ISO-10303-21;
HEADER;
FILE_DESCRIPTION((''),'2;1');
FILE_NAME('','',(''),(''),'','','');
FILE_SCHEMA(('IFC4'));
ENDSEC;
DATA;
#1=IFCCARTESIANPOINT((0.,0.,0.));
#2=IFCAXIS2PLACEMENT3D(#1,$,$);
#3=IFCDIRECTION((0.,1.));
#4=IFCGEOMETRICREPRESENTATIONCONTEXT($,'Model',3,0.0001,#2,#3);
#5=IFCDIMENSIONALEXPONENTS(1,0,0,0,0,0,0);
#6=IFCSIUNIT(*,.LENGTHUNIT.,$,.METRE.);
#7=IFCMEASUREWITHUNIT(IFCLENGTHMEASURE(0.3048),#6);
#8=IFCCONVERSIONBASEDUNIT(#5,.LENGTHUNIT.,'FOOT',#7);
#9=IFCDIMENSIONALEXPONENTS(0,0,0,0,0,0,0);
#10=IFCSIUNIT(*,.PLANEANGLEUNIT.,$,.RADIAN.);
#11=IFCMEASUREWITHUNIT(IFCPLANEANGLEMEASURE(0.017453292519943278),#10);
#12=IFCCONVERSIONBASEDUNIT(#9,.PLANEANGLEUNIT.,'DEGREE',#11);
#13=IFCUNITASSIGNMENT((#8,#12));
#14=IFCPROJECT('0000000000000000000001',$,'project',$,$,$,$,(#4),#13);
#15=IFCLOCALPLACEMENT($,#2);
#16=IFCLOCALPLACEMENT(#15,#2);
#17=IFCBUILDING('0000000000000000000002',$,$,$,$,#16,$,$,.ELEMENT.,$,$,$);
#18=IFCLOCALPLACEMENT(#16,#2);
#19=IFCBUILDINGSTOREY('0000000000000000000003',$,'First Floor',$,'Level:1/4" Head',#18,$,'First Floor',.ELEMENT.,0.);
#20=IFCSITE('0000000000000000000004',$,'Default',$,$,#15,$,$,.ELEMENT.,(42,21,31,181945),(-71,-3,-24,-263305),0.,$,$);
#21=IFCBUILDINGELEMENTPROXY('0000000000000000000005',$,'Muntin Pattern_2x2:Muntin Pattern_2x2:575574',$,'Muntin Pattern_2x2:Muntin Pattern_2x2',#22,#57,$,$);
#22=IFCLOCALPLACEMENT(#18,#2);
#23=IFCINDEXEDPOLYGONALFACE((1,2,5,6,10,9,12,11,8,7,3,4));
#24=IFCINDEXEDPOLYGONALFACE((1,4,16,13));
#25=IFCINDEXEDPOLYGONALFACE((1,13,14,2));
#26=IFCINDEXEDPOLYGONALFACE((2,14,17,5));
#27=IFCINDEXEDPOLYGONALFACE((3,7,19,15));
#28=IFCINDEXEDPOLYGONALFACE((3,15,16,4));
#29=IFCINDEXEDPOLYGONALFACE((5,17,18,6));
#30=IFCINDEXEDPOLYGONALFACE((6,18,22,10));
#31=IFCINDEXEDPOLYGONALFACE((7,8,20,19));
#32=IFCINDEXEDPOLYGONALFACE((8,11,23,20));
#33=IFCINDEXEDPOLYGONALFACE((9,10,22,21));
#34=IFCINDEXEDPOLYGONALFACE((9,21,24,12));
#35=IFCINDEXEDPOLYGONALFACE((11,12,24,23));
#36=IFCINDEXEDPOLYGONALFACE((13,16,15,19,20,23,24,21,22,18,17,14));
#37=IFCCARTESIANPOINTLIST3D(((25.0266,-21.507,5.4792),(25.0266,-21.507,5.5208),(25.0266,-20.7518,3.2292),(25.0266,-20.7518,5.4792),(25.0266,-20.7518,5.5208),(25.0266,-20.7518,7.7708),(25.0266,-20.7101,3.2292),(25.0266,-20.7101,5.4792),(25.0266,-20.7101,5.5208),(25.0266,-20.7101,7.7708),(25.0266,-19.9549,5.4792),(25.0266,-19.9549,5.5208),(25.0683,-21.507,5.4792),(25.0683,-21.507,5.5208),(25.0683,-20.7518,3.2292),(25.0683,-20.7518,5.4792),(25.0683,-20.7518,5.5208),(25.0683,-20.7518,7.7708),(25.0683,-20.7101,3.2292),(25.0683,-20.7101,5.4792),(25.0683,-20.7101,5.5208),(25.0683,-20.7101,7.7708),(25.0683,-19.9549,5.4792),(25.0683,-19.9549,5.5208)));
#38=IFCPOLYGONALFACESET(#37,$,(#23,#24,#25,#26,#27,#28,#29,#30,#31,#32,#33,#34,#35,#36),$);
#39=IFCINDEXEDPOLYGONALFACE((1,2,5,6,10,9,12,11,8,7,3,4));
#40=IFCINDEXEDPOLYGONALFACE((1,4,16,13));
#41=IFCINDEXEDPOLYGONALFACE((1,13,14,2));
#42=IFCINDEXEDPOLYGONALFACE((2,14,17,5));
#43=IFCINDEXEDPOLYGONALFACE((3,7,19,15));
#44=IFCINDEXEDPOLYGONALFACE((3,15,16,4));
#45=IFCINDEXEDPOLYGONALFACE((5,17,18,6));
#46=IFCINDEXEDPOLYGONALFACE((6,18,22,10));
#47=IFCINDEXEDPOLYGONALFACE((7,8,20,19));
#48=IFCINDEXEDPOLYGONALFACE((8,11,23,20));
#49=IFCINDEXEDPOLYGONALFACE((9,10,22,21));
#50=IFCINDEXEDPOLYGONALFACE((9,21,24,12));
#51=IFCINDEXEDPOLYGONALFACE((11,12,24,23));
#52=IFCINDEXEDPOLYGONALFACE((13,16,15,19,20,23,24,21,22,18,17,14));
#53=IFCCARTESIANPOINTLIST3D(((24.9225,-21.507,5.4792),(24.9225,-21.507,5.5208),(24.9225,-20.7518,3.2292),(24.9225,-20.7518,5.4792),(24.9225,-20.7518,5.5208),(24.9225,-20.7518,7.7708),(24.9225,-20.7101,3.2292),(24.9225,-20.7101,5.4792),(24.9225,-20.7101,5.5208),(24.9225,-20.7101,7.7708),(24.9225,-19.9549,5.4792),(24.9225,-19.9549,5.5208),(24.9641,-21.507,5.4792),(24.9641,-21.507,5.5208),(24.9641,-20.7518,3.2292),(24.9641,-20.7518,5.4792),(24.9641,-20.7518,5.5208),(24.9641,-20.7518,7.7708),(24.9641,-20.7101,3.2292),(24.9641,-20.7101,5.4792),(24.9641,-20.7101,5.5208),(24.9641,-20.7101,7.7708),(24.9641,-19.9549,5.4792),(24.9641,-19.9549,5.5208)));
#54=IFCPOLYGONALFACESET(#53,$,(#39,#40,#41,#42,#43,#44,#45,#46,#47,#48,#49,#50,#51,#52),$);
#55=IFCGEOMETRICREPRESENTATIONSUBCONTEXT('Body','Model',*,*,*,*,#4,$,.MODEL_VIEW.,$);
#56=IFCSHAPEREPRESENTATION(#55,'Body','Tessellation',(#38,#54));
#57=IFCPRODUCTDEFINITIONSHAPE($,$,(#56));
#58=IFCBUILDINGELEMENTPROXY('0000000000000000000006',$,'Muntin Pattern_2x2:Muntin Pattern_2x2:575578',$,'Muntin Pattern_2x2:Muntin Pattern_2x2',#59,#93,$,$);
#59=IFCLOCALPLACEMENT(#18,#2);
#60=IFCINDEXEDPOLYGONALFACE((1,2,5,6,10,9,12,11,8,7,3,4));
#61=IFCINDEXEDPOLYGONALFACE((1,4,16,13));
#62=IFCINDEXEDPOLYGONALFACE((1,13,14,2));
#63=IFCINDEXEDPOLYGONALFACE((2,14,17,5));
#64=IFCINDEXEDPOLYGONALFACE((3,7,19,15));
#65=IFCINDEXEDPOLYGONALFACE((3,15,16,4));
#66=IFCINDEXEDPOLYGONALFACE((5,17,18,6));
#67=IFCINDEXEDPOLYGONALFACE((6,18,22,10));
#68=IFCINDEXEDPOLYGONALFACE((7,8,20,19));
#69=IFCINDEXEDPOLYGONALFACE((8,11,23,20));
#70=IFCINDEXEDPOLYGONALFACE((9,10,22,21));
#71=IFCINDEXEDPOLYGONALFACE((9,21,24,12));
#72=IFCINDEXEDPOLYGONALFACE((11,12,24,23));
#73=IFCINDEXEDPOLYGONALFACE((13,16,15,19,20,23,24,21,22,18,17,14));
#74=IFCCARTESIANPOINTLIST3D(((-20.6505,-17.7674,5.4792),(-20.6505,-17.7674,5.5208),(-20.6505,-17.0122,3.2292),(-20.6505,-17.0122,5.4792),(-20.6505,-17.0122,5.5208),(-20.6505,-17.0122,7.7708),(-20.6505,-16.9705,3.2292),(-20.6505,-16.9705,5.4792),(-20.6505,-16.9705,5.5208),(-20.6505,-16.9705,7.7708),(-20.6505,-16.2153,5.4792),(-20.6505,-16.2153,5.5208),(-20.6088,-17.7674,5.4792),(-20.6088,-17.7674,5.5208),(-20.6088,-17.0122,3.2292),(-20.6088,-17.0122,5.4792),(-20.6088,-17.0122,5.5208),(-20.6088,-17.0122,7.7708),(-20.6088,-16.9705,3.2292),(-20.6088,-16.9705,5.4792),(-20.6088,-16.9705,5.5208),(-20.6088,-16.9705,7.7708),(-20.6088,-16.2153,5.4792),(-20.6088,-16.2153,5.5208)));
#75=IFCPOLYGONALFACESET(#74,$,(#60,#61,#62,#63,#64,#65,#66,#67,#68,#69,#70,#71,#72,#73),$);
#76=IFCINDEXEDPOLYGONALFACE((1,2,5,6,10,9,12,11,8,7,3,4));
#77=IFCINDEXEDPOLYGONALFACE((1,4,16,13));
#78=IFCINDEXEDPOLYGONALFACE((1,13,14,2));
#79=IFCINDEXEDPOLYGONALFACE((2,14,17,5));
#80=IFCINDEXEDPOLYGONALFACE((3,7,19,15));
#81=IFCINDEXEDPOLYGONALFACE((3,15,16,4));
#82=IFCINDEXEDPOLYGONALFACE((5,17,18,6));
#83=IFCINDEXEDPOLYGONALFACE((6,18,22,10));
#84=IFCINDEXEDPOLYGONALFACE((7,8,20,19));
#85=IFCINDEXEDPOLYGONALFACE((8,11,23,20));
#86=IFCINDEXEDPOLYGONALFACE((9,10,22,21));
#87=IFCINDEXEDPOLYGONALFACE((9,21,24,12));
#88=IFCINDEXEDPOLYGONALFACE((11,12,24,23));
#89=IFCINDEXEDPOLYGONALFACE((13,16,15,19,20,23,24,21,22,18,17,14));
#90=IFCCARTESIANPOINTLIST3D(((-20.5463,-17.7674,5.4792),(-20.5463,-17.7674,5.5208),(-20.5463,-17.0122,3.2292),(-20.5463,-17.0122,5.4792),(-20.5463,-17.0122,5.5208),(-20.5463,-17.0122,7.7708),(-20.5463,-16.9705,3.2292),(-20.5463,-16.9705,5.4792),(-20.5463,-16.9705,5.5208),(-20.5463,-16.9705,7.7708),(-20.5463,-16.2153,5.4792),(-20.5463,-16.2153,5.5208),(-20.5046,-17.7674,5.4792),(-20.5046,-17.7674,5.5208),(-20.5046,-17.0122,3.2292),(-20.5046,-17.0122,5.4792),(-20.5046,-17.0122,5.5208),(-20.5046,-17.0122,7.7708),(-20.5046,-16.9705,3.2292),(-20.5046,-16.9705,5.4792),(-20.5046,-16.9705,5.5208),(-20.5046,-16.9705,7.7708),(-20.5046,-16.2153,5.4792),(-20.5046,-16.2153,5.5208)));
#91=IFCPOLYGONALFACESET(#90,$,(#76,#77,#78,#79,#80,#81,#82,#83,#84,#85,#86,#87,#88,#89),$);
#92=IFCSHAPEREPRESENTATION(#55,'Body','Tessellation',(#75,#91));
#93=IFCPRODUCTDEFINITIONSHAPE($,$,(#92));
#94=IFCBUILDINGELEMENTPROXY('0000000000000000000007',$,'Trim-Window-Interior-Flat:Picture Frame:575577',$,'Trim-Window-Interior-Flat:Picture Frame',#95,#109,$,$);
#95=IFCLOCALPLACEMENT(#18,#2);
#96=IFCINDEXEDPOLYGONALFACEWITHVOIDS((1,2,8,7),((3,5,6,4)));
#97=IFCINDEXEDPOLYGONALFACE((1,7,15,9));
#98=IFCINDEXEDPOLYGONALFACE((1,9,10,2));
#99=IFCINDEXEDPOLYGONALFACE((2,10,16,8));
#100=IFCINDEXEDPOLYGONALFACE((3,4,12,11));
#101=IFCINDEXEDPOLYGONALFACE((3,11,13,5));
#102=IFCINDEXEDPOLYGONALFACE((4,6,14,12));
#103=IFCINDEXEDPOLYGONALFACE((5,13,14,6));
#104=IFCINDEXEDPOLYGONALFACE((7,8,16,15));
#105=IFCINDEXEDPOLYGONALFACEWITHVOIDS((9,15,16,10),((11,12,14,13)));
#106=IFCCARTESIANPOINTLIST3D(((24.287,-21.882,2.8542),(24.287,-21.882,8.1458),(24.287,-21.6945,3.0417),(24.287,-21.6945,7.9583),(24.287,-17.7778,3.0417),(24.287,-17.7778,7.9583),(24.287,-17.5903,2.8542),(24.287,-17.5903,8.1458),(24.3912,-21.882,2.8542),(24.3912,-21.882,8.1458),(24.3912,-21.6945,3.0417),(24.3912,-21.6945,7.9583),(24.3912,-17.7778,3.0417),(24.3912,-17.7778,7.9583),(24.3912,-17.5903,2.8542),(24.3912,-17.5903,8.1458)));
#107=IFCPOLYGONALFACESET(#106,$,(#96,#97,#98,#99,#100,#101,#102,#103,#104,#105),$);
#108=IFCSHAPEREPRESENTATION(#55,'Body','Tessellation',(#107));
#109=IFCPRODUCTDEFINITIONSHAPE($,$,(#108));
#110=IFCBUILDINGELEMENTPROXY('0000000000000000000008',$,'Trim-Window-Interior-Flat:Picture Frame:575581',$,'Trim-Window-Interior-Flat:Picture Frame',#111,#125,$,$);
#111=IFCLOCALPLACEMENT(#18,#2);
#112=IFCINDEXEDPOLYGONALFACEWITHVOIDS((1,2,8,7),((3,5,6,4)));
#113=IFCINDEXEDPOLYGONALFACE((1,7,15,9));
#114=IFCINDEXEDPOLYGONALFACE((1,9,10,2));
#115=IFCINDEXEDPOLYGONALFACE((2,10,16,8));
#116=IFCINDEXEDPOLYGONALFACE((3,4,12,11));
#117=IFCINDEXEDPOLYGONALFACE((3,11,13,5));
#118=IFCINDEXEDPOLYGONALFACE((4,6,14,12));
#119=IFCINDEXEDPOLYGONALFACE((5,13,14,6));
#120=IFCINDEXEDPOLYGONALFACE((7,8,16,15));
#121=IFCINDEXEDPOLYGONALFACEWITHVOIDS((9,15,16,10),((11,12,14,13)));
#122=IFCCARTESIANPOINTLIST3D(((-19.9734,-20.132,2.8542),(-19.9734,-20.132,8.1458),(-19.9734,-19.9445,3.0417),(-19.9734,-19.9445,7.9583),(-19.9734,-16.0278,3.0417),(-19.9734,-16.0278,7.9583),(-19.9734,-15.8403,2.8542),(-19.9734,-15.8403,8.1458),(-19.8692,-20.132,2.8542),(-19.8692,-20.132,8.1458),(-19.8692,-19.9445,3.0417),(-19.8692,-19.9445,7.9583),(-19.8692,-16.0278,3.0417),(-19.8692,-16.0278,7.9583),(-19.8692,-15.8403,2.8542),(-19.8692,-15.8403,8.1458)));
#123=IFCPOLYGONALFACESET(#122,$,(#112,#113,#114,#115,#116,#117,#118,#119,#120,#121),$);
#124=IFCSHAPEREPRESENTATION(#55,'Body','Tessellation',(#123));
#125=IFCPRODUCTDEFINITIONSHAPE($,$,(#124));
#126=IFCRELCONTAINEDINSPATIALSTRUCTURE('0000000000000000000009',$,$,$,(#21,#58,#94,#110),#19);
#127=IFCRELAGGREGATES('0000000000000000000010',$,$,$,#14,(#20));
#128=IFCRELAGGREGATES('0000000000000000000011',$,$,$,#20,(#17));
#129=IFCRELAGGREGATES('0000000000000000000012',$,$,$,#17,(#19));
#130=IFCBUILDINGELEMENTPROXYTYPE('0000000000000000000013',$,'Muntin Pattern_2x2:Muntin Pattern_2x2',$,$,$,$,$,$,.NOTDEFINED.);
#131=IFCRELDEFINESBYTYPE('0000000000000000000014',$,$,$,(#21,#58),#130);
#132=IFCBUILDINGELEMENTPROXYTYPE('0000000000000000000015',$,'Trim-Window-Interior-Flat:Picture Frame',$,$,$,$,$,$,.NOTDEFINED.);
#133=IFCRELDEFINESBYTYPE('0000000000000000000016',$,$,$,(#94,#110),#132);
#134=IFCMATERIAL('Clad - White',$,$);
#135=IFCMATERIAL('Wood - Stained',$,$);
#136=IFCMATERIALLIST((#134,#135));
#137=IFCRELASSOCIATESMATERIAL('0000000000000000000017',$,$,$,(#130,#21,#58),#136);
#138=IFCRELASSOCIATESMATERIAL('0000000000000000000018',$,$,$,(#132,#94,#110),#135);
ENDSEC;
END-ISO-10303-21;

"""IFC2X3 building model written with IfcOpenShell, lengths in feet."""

from ifc_helpers import new_model, entity, si_unit, converted_unit, direction, frame, origin, place, context, subcontext, project, spatial, polyline, outline, extrude, source, transform, mapped, material, material_list, type_object, type_shapes, element, save


model = new_model("IFC2X3")

# Units and contexts
model_context = context("Model", 3, precision=0.0001, world=origin(), true_north=direction((0.0, 1.0)))
body_context = subcontext(model_context, "Body", "Model", "MODEL_VIEW")
ifc_project = project(units=[converted_unit("LENGTHUNIT", "FOOT", entity("IfcLengthMeasure", 0.3048), si_unit("LENGTHUNIT", "METRE"), dimensions=[1, 0, 0, 0, 0, 0, 0]), converted_unit("PLANEANGLEUNIT", "DEGREE", entity("IfcPlaneAngleMeasure", 0.017453292519943278), si_unit("PLANEANGLEUNIT", "RADIAN"), dimensions=[0, 0, 0, 0, 0, 0, 0])], contexts=[model_context])

# Site, building, storey
site_placement = place(None, origin())
site = spatial("IfcSite", under=ifc_project, at=site_placement, Name="Default", CompositionType="ELEMENT", RefLatitude=(42, 21, 31, 181945), RefLongitude=(-71, -3, -24, -263305), RefElevation=0.0)
building_placement = place(site_placement, origin())
building = spatial("IfcBuilding", under=site, at=building_placement, CompositionType="ELEMENT")
storey_placement = place(building_placement, origin())
storey = spatial("IfcBuildingStorey", under=building, at=storey_placement, Name="First Floor", ObjectType="Level:1/4\" Head", LongName="First Floor", CompositionType="ELEMENT", Elevation=0.0)

# Building element proxies
ifc_material_1 = material(Name="Clad - White")
ifc_material_2 = material(Name="Wood - Stained")
ifc_material_list_1 = material_list([ifc_material_1, ifc_material_2])
building_element_proxy_type_1 = type_object("IfcBuildingElementProxyType", Name="Muntin Pattern_2x2:Muntin Pattern_2x2", PredefinedType="NOTDEFINED", material=ifc_material_list_1)
shared_shape_1 = source(origin(), body_context, "Body", "SweptSolid", [
    extrude(outline(polyline([(0.0208, -0.0208), (2.2708, -0.0208), (2.2708, 0.0208), (0.0208, 0.0208), (0.0208, 0.776), (-0.0208, 0.776), (-0.0208, 0.0208), (-2.2708, 0.0208), (-2.2708, -0.0208), (-0.0208, -0.0208), (-0.0208, -0.776), (0.0208, -0.776), (0.0208, -0.0208)])), frame((0.0, -0.0729, 2.2708), z_axis=(0.0, 1.0, 0.0), x_axis=(0.0, 0.0, 1.0)), (0.0, 0.0, 1.0), 0.0417),
    extrude(outline(polyline([(0.0208, -0.0208), (2.2708, -0.0208), (2.2708, 0.0208), (0.0208, 0.0208), (0.0208, 0.776), (-0.0208, 0.776), (-0.0208, 0.0208), (-2.2708, 0.0208), (-2.2708, -0.0208), (-0.0208, -0.0208), (-0.0208, -0.776), (0.0208, -0.776), (0.0208, -0.0208)])), frame((0.0, 0.0313, 2.2708), z_axis=(0.0, 1.0, 0.0), x_axis=(0.0, 0.0, 1.0)), (0.0, 0.0, 1.0), 0.0417),
])
type_shapes(building_element_proxy_type_1, [shared_shape_1])
for number, where, z_axis, x_axis, name in (
    (1, (24.9954, -20.7309, 3.2292), (0.0, 0.0, 1.0), (0.0, 1.0, 0.0), "Muntin Pattern_2x2:Muntin Pattern_2x2:575574"),
    (2, (-20.5775, -16.9913, 3.2292), (0.0, 0.0, 1.0), (0.0, -1.0, 0.0), "Muntin Pattern_2x2:Muntin Pattern_2x2:575578"),
):
    element("IfcBuildingElementProxy", number, at=place(storey_placement, frame(where, z_axis=z_axis, x_axis=x_axis)), inside=storey, type_object=building_element_proxy_type_1, material=ifc_material_list_1, Name=name, ObjectType="Muntin Pattern_2x2:Muntin Pattern_2x2", context=body_context, shape_type="MappedRepresentation", body=[
        mapped(shared_shape_1, transform((0.0, 0.0, 0.0), scale=1.0)),
    ])
building_element_proxy_type_2 = type_object("IfcBuildingElementProxyType", Name="Trim-Window-Interior-Flat:Picture Frame", PredefinedType="NOTDEFINED", material=ifc_material_2)
shared_shape_2 = source(origin(), body_context, "Body", "SweptSolid", [
    extrude(outline(polyline([(-2.6458, -2.1458), (2.6458, -2.1458), (2.6458, 2.1458), (-2.6458, 2.1458), (-2.6458, -2.1458)]), holes=[polyline([(-2.4583, -1.9583), (-2.4583, 1.9583), (2.4583, 1.9583), (2.4583, -1.9583), (-2.4583, -1.9583)])]), frame((0.0, 2.5, 0.0), z_axis=(0.0, 0.0, 1.0), x_axis=(0.0, 1.0, 0.0)), (0.0, 0.0, 1.0), 0.1042),
])
type_shapes(building_element_proxy_type_2, [shared_shape_2])
for number, where, z_axis, x_axis, name in (
    (3, (24.3912, -19.7361, 8.0), (-1.0, 0.0, 0.0), (0.0, 1.0, 0.0), "Trim-Window-Interior-Flat:Picture Frame:575577"),
    (4, (-19.9734, -17.9861, 8.0), (1.0, 0.0, 0.0), (0.0, -1.0, 0.0), "Trim-Window-Interior-Flat:Picture Frame:575581"),
):
    element("IfcBuildingElementProxy", number, at=place(storey_placement, frame(where, z_axis=z_axis, x_axis=x_axis)), inside=storey, type_object=building_element_proxy_type_2, material=ifc_material_2, Name=name, ObjectType="Trim-Window-Interior-Flat:Picture Frame", context=body_context, shape_type="MappedRepresentation", body=[
        mapped(shared_shape_2, transform((0.0, 0.0, 0.0), scale=1.0)),
    ])

save(model, "model.ifc")
